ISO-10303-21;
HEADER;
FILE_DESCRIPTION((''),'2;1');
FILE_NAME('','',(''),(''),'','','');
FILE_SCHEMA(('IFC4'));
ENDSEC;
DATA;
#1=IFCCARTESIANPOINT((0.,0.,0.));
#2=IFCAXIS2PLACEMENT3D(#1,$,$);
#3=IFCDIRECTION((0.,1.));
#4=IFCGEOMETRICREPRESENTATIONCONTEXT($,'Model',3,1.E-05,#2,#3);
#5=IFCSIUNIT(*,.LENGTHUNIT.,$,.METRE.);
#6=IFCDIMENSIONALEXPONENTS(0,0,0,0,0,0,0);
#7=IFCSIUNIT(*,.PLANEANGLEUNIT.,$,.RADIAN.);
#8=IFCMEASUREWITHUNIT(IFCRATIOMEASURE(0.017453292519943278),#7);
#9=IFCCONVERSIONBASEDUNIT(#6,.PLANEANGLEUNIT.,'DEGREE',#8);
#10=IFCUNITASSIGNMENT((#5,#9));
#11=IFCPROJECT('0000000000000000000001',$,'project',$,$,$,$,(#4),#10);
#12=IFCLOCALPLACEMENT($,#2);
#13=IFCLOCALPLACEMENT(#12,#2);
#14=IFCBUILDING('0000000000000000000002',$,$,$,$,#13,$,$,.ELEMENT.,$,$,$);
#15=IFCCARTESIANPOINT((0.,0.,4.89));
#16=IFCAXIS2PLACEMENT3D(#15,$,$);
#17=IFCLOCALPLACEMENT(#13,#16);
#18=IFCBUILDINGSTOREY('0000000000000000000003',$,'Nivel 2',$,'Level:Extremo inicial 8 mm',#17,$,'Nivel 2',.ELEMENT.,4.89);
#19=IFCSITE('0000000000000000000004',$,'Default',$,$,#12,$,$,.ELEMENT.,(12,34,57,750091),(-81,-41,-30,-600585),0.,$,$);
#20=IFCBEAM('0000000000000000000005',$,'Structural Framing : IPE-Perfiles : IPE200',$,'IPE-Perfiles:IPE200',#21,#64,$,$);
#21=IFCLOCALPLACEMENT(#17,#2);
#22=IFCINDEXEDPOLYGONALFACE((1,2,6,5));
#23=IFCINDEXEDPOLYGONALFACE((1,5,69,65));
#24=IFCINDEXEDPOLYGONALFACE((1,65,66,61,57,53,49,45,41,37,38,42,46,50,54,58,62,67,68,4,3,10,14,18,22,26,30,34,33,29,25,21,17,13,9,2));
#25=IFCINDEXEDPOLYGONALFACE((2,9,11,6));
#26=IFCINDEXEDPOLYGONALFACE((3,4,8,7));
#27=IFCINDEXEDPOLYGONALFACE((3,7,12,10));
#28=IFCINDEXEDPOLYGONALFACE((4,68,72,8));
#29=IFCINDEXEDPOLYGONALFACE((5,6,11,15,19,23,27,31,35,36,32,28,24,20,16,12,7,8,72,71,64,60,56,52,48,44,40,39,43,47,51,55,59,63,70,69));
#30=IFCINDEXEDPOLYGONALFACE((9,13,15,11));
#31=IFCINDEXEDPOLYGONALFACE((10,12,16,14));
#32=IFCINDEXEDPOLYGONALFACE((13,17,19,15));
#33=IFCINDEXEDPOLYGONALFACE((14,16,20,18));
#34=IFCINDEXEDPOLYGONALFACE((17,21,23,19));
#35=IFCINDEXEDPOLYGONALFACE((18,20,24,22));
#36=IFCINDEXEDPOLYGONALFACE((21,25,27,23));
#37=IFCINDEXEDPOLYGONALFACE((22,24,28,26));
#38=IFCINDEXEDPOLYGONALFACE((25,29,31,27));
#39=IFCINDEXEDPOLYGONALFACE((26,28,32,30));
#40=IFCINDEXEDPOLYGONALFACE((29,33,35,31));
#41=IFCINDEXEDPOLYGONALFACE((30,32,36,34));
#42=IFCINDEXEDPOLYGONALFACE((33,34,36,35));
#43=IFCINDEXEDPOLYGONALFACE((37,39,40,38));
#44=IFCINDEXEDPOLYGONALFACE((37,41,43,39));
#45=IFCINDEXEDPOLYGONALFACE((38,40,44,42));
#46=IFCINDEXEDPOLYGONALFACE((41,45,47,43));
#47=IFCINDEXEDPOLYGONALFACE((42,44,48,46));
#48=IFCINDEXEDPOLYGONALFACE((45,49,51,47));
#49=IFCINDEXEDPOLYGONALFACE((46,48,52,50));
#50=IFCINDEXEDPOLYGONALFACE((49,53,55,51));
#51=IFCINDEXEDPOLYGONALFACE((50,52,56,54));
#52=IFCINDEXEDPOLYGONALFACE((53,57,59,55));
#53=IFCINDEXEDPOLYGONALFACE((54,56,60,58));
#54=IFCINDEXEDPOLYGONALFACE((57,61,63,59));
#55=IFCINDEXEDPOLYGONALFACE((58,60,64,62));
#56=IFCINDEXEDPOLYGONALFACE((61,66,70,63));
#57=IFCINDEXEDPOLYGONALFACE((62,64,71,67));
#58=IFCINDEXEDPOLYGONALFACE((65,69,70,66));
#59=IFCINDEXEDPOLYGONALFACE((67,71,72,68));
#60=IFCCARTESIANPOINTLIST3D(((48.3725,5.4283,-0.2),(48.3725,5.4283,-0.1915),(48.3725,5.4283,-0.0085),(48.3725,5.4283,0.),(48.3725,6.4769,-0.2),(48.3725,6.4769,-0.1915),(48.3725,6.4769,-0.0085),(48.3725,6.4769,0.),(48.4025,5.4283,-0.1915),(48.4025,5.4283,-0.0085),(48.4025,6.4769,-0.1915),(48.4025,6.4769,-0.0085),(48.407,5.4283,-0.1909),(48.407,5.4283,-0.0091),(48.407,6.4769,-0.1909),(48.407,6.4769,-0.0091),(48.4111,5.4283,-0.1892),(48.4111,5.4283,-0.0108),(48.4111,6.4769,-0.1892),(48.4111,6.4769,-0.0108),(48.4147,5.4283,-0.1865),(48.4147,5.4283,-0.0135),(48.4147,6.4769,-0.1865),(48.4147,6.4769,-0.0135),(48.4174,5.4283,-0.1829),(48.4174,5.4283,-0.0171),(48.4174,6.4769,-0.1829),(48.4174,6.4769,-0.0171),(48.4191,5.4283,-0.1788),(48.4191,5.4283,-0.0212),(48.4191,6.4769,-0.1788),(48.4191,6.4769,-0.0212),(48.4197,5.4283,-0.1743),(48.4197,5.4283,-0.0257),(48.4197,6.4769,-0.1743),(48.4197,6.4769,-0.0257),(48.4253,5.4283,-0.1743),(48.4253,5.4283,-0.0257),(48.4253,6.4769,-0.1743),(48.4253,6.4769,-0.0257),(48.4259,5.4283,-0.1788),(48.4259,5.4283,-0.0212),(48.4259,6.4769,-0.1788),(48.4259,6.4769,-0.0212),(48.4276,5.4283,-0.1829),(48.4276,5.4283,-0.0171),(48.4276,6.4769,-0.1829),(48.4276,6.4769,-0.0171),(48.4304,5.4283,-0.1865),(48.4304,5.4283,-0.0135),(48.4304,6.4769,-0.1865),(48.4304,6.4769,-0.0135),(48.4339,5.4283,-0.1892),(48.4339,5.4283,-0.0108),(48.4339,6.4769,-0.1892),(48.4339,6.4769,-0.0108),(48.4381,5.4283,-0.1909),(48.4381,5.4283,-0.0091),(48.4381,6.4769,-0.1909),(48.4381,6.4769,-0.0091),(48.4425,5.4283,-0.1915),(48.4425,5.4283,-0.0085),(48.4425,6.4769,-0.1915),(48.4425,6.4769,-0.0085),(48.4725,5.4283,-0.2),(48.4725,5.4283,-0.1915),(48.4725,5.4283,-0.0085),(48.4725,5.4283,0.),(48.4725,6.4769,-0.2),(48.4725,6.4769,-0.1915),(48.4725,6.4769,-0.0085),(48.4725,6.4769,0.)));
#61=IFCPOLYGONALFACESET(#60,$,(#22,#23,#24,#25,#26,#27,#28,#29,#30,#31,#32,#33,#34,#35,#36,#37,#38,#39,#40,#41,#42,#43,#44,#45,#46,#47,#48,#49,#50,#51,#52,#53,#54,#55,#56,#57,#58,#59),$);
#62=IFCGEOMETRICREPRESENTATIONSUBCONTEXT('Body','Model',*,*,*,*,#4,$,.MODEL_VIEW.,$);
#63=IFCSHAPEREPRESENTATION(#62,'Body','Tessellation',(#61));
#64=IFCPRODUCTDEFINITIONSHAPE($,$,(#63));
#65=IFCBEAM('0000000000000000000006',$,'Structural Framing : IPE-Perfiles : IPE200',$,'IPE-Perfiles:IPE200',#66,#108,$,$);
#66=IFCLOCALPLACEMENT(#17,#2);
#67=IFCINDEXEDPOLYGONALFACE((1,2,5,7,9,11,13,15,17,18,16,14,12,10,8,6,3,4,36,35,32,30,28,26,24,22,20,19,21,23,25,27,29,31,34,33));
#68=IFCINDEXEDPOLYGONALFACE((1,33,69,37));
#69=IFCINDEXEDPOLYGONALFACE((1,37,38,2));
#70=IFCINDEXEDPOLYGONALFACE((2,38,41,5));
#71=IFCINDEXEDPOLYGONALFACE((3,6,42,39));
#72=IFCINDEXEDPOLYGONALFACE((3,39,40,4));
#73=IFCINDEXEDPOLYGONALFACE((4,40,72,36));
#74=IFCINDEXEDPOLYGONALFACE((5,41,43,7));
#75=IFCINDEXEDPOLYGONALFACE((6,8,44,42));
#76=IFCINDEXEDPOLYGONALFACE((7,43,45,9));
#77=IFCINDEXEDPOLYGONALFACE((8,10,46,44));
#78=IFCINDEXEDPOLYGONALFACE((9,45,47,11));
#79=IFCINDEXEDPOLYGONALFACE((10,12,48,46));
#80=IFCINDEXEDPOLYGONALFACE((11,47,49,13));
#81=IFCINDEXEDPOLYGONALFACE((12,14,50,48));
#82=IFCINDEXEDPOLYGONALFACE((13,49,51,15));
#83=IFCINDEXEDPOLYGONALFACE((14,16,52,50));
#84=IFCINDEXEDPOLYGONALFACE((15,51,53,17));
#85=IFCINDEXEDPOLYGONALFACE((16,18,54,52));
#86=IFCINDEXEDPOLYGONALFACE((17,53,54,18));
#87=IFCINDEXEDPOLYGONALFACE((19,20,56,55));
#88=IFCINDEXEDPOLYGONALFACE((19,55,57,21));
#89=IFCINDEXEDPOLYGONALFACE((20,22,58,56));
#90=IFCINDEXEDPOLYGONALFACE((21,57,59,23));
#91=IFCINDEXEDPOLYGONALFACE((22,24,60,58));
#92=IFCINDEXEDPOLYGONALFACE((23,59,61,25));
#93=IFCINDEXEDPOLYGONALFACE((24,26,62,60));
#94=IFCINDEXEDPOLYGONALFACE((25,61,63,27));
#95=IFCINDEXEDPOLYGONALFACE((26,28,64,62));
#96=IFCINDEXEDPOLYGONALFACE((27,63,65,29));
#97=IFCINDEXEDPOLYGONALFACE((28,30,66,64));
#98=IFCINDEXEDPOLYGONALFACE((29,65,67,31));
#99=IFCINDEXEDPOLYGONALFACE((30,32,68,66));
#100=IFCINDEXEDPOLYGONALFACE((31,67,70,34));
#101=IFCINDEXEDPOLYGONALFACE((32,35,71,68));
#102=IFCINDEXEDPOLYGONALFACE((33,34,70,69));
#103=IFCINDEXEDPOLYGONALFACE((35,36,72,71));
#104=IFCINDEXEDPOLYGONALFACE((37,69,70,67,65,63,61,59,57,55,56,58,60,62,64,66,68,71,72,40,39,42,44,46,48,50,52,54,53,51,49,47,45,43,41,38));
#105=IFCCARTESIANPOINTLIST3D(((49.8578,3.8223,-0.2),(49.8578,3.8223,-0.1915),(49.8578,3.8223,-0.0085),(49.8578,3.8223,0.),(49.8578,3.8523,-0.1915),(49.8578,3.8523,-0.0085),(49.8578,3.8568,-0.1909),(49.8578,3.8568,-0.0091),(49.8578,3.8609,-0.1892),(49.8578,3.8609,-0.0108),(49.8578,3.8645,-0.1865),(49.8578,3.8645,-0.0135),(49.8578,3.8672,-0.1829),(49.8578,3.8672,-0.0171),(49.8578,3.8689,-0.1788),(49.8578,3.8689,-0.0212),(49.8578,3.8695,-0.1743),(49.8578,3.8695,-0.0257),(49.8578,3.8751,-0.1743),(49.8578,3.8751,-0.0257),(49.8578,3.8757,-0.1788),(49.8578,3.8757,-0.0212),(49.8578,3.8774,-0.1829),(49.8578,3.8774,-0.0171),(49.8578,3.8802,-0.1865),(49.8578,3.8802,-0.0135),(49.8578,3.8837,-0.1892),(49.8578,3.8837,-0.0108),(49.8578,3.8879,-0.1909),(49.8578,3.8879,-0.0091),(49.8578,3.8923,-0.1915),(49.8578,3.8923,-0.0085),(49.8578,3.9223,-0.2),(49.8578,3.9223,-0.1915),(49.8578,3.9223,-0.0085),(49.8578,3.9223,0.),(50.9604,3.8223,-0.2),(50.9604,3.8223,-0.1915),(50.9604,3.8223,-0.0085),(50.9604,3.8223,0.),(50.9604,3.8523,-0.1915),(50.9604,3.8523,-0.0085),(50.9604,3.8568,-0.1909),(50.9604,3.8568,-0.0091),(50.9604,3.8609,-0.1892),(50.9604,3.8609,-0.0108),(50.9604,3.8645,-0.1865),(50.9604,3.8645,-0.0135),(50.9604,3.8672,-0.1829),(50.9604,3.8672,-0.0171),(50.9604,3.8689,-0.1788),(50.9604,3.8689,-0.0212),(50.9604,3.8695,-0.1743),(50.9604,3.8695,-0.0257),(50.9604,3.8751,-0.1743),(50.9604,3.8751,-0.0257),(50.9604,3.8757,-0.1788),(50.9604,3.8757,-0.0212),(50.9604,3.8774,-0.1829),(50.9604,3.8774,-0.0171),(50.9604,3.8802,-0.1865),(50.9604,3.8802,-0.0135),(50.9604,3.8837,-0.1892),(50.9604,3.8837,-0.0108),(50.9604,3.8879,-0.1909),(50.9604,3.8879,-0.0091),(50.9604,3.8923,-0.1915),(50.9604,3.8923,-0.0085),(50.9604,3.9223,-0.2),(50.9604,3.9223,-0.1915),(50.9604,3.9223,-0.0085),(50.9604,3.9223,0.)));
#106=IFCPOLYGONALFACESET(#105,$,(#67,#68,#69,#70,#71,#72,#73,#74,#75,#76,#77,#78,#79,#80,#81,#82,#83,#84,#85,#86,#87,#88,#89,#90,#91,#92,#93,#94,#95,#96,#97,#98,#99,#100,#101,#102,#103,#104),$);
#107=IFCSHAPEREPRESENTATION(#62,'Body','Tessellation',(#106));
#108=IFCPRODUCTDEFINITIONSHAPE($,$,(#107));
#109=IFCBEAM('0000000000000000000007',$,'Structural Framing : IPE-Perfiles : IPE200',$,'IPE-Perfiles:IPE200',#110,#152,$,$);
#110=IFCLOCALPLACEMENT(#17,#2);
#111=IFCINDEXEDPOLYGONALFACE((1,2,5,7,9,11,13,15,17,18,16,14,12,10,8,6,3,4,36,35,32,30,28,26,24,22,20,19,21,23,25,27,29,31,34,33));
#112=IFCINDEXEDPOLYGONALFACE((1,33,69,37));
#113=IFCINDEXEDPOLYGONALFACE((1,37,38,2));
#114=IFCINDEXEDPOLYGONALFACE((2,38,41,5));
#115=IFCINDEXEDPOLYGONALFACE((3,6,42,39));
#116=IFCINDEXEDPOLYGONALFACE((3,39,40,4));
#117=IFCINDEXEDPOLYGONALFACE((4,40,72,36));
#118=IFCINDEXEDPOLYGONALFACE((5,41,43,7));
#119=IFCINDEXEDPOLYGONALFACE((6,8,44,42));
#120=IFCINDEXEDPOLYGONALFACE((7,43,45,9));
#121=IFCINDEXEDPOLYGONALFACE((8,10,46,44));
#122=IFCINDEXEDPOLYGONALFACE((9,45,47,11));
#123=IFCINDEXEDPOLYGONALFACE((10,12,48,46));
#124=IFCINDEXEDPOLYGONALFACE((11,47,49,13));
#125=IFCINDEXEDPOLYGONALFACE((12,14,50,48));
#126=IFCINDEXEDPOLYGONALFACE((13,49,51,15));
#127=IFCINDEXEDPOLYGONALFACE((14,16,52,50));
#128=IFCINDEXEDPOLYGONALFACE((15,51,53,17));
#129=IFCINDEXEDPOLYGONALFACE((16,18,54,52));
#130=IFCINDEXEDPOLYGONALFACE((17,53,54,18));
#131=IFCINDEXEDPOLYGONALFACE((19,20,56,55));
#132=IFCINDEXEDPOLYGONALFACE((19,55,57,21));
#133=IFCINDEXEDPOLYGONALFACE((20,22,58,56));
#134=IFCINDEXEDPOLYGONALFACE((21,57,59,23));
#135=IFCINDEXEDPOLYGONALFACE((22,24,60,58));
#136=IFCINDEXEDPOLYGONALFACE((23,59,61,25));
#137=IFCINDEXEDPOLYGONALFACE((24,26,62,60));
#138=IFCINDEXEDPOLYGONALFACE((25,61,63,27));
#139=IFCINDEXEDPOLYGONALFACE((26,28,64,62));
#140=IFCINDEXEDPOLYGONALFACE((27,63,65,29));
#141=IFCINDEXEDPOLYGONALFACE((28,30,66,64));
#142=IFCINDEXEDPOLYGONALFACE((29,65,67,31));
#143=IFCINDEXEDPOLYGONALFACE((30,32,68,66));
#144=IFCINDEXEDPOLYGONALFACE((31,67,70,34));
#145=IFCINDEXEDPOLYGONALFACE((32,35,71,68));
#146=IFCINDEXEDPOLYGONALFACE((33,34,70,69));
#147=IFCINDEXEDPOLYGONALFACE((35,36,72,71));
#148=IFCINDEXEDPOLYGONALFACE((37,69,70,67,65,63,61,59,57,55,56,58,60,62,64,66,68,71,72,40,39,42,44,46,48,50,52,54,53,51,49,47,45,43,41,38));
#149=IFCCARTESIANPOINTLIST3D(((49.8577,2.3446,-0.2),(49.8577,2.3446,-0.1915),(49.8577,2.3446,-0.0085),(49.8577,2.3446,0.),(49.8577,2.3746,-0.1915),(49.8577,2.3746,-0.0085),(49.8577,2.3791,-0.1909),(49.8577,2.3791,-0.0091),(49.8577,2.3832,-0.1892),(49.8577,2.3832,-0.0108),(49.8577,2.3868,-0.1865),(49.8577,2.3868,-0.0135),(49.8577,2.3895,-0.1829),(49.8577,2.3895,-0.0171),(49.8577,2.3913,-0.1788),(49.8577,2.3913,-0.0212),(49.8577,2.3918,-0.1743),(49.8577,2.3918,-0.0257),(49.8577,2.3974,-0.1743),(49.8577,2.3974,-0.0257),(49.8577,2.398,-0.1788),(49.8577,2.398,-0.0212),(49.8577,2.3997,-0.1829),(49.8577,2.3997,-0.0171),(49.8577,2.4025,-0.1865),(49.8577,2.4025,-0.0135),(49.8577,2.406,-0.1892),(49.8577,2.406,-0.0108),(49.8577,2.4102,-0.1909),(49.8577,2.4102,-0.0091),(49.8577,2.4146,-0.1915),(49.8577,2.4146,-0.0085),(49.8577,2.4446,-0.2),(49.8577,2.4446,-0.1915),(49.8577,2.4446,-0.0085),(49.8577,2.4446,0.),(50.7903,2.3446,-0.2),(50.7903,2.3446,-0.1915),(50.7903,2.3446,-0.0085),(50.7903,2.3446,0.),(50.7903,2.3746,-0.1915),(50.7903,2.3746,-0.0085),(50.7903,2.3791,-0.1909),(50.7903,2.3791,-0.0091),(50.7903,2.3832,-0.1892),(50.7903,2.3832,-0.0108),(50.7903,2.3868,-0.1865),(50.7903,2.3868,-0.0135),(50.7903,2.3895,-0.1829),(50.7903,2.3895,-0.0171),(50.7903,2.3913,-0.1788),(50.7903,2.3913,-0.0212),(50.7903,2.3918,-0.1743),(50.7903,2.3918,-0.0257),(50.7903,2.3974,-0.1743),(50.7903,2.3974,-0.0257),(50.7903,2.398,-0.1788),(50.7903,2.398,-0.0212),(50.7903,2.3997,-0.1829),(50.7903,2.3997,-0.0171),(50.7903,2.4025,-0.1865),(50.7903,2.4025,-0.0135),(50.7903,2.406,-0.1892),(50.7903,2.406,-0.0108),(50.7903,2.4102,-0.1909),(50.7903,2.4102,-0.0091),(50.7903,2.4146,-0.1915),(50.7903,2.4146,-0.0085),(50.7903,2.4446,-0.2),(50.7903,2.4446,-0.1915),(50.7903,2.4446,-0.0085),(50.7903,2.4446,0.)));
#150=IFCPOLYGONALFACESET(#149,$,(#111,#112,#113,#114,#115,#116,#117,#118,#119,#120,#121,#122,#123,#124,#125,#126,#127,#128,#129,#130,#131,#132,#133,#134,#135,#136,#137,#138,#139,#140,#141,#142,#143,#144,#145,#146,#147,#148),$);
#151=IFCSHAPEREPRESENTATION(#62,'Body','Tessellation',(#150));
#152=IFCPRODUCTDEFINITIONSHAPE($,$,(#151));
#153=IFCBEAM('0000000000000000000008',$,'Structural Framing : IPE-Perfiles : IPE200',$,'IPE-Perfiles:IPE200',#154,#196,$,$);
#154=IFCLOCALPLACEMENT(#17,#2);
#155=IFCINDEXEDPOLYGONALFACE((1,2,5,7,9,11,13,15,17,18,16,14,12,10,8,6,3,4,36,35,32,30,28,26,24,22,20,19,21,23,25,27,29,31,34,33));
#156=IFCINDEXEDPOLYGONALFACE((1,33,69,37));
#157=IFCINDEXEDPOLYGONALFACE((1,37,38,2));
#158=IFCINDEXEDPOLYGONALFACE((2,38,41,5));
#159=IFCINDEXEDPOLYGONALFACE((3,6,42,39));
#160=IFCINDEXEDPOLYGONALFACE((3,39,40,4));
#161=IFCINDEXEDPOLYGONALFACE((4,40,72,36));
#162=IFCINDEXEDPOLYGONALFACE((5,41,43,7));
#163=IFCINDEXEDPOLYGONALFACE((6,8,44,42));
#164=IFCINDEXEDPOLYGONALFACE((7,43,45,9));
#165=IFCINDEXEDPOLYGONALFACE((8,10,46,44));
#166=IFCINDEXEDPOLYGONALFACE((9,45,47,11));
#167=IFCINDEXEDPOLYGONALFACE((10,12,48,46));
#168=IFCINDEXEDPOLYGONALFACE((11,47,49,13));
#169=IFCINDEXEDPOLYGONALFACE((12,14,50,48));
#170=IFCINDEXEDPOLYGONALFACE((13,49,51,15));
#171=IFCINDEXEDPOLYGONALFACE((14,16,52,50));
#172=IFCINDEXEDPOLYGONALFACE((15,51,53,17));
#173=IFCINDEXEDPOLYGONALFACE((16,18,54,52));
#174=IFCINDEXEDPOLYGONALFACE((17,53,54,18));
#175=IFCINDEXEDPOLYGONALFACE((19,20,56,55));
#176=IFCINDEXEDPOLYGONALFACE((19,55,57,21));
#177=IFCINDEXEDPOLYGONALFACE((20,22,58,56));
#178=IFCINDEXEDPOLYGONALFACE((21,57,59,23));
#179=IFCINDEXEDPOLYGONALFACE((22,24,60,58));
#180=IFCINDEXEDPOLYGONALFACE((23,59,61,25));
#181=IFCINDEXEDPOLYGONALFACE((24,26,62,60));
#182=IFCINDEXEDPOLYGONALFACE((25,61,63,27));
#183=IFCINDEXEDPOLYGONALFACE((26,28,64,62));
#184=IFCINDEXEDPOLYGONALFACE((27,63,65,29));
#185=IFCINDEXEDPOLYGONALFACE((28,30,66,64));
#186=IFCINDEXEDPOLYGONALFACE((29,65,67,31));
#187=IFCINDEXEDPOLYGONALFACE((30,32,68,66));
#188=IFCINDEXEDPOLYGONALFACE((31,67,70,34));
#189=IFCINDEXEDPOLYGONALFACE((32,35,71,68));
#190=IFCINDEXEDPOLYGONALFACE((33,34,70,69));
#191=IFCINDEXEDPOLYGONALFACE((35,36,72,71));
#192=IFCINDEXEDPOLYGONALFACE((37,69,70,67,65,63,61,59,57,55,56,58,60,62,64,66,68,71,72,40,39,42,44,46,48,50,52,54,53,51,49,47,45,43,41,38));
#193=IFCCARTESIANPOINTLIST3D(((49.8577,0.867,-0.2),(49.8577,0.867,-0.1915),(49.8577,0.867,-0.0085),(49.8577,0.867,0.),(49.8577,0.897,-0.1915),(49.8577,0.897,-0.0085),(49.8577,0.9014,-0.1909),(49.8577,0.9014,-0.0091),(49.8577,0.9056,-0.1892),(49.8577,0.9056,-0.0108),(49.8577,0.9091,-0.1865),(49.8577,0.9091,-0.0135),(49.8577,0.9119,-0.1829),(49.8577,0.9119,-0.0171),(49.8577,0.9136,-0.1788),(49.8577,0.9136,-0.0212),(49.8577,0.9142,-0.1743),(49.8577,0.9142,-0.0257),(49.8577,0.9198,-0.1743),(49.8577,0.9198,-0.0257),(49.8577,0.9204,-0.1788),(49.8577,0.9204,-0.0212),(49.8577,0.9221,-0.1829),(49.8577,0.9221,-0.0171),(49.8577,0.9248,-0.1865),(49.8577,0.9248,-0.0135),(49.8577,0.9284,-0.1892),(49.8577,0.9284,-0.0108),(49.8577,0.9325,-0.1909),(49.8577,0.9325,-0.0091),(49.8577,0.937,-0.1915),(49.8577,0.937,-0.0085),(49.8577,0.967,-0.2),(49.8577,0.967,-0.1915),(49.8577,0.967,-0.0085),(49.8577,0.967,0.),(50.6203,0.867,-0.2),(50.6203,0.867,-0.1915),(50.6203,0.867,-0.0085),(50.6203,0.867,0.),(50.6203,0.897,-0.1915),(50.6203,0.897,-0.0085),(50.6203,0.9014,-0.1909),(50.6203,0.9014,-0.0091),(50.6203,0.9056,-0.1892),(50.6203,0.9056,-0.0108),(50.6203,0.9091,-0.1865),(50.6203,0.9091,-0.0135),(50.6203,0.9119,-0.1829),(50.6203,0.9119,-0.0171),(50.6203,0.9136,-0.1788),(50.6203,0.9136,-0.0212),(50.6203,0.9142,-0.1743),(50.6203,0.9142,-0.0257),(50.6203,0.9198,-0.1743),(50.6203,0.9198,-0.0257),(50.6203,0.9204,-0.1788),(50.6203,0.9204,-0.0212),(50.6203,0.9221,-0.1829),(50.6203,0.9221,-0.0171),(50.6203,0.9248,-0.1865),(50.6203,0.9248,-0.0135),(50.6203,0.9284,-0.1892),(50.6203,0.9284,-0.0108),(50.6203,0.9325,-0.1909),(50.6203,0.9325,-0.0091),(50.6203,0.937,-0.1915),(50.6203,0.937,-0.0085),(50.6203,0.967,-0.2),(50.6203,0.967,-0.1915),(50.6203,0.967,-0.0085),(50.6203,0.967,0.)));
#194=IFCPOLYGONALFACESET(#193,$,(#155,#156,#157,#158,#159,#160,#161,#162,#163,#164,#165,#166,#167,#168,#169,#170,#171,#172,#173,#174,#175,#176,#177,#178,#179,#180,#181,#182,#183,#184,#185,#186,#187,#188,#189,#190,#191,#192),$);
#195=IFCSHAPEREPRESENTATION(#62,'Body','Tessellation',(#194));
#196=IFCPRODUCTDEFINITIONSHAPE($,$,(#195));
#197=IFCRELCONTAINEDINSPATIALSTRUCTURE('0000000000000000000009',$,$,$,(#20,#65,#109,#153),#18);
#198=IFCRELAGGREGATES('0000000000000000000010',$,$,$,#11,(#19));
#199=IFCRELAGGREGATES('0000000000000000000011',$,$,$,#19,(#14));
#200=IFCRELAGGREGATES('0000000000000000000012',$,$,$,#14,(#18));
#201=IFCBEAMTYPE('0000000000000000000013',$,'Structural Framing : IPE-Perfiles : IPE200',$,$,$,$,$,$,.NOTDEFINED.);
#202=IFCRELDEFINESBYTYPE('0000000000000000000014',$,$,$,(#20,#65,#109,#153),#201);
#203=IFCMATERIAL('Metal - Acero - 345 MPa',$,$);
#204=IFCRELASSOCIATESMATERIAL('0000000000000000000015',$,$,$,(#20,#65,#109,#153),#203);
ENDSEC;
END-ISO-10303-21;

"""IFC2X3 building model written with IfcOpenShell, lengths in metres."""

from ifc_helpers import new_model, entity, si_unit, converted_unit, direction, frame, frame_2d, origin, place, context, subcontext, project, spatial, i_section, extrude, material, type_object, element, save


model = new_model("IFC2X3")

# Units and contexts
model_context = context("Model", 3, precision=1e-05, world=origin(), true_north=direction((0.0, 1.0)))
body_context = subcontext(model_context, "Body", "Model", "MODEL_VIEW")
ifc_project = project(units=[si_unit("LENGTHUNIT", "METRE"), converted_unit("PLANEANGLEUNIT", "DEGREE", entity("IfcRatioMeasure", 0.017453292519943278), si_unit("PLANEANGLEUNIT", "RADIAN"), dimensions=[0, 0, 0, 0, 0, 0, 0])], contexts=[model_context])

# Site, building, storey
site_placement = place(None, origin())
site = spatial("IfcSite", under=ifc_project, at=site_placement, Name="Default", CompositionType="ELEMENT", RefLatitude=(12, 34, 57, 750091), RefLongitude=(-81, -41, -30, -600585), RefElevation=0.0)
building_placement = place(site_placement, origin())
building = spatial("IfcBuilding", under=site, at=building_placement, CompositionType="ELEMENT")
storey_placement = place(building_placement, frame((0.0, 0.0, 4.89)))
storey = spatial("IfcBuildingStorey", under=building, at=storey_placement, Name="Nivel 2", ObjectType="Level:Extremo inicial 8 mm", LongName="Nivel 2", CompositionType="ELEMENT", Elevation=4.89)

# Shared definitions
ifc_material_1 = material(Name="Metal - Acero - 345 MPa")

# Beams
beam_type_1 = type_object("IfcBeamType", Name="Structural Framing : IPE-Perfiles : IPE200", PredefinedType="NOTDEFINED")
beam_1_placement = place(storey_placement, frame((48.4225, 5.3471, 0.0), z_axis=(0.0, 0.0, 1.0), x_axis=(0.0, 1.0, 0.0)))
element("IfcBeam", 1, at=beam_1_placement, inside=storey, type_object=beam_type_1, material=ifc_material_1, Name="Structural Framing : IPE-Perfiles : IPE200", ObjectType="IPE-Perfiles:IPE200", context=body_context, shape_type="SweptSolid", body=[
    extrude(i_section(OverallWidth=0.1, OverallDepth=0.2, WebThickness=0.0056, FlangeThickness=0.0085, FilletRadius=0.0172, at=frame_2d((0.0, 0.0), x_axis=(0.0, 1.0))), frame((0.0811, 0.0, -0.1), z_axis=(1.0, 0.0, 0.0), x_axis=(0.0, 0.0, -1.0)), (0.0, 0.0, 1.0), 1.0486),
])
beam_2_placement = place(storey_placement, frame((49.795, 3.8723, 0.0)))
element("IfcBeam", 2, at=beam_2_placement, inside=storey, type_object=beam_type_1, material=ifc_material_1, Name="Structural Framing : IPE-Perfiles : IPE200", ObjectType="IPE-Perfiles:IPE200", context=body_context, shape_type="SweptSolid", body=[
    extrude(i_section(OverallWidth=0.1, OverallDepth=0.2, WebThickness=0.0056, FlangeThickness=0.0085, FilletRadius=0.0172, at=frame_2d((0.0, 0.0), x_axis=(0.0, 1.0))), frame((0.0628, 0.0, -0.1), z_axis=(1.0, 0.0, 0.0), x_axis=(0.0, 0.0, -1.0)), (0.0, 0.0, 1.0), 1.1026),
])
beam_3_placement = place(storey_placement, frame((49.795, 2.3946, 0.0)))
element("IfcBeam", 3, at=beam_3_placement, inside=storey, type_object=beam_type_1, material=ifc_material_1, Name="Structural Framing : IPE-Perfiles : IPE200", ObjectType="IPE-Perfiles:IPE200", context=body_context, shape_type="SweptSolid", body=[
    extrude(i_section(OverallWidth=0.1, OverallDepth=0.2, WebThickness=0.0056, FlangeThickness=0.0085, FilletRadius=0.0172, at=frame_2d((0.0, 0.0), x_axis=(0.0, 1.0))), frame((0.0627, 0.0, -0.1), z_axis=(1.0, 0.0, 0.0), x_axis=(0.0, 0.0, -1.0)), (0.0, 0.0, 1.0), 0.9326),
])
beam_4_placement = place(storey_placement, frame((49.795, 0.917, 0.0)))
element("IfcBeam", 4, at=beam_4_placement, inside=storey, type_object=beam_type_1, material=ifc_material_1, Name="Structural Framing : IPE-Perfiles : IPE200", ObjectType="IPE-Perfiles:IPE200", context=body_context, shape_type="SweptSolid", body=[
    extrude(i_section(OverallWidth=0.1, OverallDepth=0.2, WebThickness=0.0056, FlangeThickness=0.0085, FilletRadius=0.0172, at=frame_2d((0.0, 0.0), x_axis=(0.0, 1.0))), frame((0.0627, 0.0, -0.1), z_axis=(1.0, 0.0, 0.0), x_axis=(0.0, 0.0, -1.0)), (0.0, 0.0, 1.0), 0.7626),
])

save(model, "model.ifc")
